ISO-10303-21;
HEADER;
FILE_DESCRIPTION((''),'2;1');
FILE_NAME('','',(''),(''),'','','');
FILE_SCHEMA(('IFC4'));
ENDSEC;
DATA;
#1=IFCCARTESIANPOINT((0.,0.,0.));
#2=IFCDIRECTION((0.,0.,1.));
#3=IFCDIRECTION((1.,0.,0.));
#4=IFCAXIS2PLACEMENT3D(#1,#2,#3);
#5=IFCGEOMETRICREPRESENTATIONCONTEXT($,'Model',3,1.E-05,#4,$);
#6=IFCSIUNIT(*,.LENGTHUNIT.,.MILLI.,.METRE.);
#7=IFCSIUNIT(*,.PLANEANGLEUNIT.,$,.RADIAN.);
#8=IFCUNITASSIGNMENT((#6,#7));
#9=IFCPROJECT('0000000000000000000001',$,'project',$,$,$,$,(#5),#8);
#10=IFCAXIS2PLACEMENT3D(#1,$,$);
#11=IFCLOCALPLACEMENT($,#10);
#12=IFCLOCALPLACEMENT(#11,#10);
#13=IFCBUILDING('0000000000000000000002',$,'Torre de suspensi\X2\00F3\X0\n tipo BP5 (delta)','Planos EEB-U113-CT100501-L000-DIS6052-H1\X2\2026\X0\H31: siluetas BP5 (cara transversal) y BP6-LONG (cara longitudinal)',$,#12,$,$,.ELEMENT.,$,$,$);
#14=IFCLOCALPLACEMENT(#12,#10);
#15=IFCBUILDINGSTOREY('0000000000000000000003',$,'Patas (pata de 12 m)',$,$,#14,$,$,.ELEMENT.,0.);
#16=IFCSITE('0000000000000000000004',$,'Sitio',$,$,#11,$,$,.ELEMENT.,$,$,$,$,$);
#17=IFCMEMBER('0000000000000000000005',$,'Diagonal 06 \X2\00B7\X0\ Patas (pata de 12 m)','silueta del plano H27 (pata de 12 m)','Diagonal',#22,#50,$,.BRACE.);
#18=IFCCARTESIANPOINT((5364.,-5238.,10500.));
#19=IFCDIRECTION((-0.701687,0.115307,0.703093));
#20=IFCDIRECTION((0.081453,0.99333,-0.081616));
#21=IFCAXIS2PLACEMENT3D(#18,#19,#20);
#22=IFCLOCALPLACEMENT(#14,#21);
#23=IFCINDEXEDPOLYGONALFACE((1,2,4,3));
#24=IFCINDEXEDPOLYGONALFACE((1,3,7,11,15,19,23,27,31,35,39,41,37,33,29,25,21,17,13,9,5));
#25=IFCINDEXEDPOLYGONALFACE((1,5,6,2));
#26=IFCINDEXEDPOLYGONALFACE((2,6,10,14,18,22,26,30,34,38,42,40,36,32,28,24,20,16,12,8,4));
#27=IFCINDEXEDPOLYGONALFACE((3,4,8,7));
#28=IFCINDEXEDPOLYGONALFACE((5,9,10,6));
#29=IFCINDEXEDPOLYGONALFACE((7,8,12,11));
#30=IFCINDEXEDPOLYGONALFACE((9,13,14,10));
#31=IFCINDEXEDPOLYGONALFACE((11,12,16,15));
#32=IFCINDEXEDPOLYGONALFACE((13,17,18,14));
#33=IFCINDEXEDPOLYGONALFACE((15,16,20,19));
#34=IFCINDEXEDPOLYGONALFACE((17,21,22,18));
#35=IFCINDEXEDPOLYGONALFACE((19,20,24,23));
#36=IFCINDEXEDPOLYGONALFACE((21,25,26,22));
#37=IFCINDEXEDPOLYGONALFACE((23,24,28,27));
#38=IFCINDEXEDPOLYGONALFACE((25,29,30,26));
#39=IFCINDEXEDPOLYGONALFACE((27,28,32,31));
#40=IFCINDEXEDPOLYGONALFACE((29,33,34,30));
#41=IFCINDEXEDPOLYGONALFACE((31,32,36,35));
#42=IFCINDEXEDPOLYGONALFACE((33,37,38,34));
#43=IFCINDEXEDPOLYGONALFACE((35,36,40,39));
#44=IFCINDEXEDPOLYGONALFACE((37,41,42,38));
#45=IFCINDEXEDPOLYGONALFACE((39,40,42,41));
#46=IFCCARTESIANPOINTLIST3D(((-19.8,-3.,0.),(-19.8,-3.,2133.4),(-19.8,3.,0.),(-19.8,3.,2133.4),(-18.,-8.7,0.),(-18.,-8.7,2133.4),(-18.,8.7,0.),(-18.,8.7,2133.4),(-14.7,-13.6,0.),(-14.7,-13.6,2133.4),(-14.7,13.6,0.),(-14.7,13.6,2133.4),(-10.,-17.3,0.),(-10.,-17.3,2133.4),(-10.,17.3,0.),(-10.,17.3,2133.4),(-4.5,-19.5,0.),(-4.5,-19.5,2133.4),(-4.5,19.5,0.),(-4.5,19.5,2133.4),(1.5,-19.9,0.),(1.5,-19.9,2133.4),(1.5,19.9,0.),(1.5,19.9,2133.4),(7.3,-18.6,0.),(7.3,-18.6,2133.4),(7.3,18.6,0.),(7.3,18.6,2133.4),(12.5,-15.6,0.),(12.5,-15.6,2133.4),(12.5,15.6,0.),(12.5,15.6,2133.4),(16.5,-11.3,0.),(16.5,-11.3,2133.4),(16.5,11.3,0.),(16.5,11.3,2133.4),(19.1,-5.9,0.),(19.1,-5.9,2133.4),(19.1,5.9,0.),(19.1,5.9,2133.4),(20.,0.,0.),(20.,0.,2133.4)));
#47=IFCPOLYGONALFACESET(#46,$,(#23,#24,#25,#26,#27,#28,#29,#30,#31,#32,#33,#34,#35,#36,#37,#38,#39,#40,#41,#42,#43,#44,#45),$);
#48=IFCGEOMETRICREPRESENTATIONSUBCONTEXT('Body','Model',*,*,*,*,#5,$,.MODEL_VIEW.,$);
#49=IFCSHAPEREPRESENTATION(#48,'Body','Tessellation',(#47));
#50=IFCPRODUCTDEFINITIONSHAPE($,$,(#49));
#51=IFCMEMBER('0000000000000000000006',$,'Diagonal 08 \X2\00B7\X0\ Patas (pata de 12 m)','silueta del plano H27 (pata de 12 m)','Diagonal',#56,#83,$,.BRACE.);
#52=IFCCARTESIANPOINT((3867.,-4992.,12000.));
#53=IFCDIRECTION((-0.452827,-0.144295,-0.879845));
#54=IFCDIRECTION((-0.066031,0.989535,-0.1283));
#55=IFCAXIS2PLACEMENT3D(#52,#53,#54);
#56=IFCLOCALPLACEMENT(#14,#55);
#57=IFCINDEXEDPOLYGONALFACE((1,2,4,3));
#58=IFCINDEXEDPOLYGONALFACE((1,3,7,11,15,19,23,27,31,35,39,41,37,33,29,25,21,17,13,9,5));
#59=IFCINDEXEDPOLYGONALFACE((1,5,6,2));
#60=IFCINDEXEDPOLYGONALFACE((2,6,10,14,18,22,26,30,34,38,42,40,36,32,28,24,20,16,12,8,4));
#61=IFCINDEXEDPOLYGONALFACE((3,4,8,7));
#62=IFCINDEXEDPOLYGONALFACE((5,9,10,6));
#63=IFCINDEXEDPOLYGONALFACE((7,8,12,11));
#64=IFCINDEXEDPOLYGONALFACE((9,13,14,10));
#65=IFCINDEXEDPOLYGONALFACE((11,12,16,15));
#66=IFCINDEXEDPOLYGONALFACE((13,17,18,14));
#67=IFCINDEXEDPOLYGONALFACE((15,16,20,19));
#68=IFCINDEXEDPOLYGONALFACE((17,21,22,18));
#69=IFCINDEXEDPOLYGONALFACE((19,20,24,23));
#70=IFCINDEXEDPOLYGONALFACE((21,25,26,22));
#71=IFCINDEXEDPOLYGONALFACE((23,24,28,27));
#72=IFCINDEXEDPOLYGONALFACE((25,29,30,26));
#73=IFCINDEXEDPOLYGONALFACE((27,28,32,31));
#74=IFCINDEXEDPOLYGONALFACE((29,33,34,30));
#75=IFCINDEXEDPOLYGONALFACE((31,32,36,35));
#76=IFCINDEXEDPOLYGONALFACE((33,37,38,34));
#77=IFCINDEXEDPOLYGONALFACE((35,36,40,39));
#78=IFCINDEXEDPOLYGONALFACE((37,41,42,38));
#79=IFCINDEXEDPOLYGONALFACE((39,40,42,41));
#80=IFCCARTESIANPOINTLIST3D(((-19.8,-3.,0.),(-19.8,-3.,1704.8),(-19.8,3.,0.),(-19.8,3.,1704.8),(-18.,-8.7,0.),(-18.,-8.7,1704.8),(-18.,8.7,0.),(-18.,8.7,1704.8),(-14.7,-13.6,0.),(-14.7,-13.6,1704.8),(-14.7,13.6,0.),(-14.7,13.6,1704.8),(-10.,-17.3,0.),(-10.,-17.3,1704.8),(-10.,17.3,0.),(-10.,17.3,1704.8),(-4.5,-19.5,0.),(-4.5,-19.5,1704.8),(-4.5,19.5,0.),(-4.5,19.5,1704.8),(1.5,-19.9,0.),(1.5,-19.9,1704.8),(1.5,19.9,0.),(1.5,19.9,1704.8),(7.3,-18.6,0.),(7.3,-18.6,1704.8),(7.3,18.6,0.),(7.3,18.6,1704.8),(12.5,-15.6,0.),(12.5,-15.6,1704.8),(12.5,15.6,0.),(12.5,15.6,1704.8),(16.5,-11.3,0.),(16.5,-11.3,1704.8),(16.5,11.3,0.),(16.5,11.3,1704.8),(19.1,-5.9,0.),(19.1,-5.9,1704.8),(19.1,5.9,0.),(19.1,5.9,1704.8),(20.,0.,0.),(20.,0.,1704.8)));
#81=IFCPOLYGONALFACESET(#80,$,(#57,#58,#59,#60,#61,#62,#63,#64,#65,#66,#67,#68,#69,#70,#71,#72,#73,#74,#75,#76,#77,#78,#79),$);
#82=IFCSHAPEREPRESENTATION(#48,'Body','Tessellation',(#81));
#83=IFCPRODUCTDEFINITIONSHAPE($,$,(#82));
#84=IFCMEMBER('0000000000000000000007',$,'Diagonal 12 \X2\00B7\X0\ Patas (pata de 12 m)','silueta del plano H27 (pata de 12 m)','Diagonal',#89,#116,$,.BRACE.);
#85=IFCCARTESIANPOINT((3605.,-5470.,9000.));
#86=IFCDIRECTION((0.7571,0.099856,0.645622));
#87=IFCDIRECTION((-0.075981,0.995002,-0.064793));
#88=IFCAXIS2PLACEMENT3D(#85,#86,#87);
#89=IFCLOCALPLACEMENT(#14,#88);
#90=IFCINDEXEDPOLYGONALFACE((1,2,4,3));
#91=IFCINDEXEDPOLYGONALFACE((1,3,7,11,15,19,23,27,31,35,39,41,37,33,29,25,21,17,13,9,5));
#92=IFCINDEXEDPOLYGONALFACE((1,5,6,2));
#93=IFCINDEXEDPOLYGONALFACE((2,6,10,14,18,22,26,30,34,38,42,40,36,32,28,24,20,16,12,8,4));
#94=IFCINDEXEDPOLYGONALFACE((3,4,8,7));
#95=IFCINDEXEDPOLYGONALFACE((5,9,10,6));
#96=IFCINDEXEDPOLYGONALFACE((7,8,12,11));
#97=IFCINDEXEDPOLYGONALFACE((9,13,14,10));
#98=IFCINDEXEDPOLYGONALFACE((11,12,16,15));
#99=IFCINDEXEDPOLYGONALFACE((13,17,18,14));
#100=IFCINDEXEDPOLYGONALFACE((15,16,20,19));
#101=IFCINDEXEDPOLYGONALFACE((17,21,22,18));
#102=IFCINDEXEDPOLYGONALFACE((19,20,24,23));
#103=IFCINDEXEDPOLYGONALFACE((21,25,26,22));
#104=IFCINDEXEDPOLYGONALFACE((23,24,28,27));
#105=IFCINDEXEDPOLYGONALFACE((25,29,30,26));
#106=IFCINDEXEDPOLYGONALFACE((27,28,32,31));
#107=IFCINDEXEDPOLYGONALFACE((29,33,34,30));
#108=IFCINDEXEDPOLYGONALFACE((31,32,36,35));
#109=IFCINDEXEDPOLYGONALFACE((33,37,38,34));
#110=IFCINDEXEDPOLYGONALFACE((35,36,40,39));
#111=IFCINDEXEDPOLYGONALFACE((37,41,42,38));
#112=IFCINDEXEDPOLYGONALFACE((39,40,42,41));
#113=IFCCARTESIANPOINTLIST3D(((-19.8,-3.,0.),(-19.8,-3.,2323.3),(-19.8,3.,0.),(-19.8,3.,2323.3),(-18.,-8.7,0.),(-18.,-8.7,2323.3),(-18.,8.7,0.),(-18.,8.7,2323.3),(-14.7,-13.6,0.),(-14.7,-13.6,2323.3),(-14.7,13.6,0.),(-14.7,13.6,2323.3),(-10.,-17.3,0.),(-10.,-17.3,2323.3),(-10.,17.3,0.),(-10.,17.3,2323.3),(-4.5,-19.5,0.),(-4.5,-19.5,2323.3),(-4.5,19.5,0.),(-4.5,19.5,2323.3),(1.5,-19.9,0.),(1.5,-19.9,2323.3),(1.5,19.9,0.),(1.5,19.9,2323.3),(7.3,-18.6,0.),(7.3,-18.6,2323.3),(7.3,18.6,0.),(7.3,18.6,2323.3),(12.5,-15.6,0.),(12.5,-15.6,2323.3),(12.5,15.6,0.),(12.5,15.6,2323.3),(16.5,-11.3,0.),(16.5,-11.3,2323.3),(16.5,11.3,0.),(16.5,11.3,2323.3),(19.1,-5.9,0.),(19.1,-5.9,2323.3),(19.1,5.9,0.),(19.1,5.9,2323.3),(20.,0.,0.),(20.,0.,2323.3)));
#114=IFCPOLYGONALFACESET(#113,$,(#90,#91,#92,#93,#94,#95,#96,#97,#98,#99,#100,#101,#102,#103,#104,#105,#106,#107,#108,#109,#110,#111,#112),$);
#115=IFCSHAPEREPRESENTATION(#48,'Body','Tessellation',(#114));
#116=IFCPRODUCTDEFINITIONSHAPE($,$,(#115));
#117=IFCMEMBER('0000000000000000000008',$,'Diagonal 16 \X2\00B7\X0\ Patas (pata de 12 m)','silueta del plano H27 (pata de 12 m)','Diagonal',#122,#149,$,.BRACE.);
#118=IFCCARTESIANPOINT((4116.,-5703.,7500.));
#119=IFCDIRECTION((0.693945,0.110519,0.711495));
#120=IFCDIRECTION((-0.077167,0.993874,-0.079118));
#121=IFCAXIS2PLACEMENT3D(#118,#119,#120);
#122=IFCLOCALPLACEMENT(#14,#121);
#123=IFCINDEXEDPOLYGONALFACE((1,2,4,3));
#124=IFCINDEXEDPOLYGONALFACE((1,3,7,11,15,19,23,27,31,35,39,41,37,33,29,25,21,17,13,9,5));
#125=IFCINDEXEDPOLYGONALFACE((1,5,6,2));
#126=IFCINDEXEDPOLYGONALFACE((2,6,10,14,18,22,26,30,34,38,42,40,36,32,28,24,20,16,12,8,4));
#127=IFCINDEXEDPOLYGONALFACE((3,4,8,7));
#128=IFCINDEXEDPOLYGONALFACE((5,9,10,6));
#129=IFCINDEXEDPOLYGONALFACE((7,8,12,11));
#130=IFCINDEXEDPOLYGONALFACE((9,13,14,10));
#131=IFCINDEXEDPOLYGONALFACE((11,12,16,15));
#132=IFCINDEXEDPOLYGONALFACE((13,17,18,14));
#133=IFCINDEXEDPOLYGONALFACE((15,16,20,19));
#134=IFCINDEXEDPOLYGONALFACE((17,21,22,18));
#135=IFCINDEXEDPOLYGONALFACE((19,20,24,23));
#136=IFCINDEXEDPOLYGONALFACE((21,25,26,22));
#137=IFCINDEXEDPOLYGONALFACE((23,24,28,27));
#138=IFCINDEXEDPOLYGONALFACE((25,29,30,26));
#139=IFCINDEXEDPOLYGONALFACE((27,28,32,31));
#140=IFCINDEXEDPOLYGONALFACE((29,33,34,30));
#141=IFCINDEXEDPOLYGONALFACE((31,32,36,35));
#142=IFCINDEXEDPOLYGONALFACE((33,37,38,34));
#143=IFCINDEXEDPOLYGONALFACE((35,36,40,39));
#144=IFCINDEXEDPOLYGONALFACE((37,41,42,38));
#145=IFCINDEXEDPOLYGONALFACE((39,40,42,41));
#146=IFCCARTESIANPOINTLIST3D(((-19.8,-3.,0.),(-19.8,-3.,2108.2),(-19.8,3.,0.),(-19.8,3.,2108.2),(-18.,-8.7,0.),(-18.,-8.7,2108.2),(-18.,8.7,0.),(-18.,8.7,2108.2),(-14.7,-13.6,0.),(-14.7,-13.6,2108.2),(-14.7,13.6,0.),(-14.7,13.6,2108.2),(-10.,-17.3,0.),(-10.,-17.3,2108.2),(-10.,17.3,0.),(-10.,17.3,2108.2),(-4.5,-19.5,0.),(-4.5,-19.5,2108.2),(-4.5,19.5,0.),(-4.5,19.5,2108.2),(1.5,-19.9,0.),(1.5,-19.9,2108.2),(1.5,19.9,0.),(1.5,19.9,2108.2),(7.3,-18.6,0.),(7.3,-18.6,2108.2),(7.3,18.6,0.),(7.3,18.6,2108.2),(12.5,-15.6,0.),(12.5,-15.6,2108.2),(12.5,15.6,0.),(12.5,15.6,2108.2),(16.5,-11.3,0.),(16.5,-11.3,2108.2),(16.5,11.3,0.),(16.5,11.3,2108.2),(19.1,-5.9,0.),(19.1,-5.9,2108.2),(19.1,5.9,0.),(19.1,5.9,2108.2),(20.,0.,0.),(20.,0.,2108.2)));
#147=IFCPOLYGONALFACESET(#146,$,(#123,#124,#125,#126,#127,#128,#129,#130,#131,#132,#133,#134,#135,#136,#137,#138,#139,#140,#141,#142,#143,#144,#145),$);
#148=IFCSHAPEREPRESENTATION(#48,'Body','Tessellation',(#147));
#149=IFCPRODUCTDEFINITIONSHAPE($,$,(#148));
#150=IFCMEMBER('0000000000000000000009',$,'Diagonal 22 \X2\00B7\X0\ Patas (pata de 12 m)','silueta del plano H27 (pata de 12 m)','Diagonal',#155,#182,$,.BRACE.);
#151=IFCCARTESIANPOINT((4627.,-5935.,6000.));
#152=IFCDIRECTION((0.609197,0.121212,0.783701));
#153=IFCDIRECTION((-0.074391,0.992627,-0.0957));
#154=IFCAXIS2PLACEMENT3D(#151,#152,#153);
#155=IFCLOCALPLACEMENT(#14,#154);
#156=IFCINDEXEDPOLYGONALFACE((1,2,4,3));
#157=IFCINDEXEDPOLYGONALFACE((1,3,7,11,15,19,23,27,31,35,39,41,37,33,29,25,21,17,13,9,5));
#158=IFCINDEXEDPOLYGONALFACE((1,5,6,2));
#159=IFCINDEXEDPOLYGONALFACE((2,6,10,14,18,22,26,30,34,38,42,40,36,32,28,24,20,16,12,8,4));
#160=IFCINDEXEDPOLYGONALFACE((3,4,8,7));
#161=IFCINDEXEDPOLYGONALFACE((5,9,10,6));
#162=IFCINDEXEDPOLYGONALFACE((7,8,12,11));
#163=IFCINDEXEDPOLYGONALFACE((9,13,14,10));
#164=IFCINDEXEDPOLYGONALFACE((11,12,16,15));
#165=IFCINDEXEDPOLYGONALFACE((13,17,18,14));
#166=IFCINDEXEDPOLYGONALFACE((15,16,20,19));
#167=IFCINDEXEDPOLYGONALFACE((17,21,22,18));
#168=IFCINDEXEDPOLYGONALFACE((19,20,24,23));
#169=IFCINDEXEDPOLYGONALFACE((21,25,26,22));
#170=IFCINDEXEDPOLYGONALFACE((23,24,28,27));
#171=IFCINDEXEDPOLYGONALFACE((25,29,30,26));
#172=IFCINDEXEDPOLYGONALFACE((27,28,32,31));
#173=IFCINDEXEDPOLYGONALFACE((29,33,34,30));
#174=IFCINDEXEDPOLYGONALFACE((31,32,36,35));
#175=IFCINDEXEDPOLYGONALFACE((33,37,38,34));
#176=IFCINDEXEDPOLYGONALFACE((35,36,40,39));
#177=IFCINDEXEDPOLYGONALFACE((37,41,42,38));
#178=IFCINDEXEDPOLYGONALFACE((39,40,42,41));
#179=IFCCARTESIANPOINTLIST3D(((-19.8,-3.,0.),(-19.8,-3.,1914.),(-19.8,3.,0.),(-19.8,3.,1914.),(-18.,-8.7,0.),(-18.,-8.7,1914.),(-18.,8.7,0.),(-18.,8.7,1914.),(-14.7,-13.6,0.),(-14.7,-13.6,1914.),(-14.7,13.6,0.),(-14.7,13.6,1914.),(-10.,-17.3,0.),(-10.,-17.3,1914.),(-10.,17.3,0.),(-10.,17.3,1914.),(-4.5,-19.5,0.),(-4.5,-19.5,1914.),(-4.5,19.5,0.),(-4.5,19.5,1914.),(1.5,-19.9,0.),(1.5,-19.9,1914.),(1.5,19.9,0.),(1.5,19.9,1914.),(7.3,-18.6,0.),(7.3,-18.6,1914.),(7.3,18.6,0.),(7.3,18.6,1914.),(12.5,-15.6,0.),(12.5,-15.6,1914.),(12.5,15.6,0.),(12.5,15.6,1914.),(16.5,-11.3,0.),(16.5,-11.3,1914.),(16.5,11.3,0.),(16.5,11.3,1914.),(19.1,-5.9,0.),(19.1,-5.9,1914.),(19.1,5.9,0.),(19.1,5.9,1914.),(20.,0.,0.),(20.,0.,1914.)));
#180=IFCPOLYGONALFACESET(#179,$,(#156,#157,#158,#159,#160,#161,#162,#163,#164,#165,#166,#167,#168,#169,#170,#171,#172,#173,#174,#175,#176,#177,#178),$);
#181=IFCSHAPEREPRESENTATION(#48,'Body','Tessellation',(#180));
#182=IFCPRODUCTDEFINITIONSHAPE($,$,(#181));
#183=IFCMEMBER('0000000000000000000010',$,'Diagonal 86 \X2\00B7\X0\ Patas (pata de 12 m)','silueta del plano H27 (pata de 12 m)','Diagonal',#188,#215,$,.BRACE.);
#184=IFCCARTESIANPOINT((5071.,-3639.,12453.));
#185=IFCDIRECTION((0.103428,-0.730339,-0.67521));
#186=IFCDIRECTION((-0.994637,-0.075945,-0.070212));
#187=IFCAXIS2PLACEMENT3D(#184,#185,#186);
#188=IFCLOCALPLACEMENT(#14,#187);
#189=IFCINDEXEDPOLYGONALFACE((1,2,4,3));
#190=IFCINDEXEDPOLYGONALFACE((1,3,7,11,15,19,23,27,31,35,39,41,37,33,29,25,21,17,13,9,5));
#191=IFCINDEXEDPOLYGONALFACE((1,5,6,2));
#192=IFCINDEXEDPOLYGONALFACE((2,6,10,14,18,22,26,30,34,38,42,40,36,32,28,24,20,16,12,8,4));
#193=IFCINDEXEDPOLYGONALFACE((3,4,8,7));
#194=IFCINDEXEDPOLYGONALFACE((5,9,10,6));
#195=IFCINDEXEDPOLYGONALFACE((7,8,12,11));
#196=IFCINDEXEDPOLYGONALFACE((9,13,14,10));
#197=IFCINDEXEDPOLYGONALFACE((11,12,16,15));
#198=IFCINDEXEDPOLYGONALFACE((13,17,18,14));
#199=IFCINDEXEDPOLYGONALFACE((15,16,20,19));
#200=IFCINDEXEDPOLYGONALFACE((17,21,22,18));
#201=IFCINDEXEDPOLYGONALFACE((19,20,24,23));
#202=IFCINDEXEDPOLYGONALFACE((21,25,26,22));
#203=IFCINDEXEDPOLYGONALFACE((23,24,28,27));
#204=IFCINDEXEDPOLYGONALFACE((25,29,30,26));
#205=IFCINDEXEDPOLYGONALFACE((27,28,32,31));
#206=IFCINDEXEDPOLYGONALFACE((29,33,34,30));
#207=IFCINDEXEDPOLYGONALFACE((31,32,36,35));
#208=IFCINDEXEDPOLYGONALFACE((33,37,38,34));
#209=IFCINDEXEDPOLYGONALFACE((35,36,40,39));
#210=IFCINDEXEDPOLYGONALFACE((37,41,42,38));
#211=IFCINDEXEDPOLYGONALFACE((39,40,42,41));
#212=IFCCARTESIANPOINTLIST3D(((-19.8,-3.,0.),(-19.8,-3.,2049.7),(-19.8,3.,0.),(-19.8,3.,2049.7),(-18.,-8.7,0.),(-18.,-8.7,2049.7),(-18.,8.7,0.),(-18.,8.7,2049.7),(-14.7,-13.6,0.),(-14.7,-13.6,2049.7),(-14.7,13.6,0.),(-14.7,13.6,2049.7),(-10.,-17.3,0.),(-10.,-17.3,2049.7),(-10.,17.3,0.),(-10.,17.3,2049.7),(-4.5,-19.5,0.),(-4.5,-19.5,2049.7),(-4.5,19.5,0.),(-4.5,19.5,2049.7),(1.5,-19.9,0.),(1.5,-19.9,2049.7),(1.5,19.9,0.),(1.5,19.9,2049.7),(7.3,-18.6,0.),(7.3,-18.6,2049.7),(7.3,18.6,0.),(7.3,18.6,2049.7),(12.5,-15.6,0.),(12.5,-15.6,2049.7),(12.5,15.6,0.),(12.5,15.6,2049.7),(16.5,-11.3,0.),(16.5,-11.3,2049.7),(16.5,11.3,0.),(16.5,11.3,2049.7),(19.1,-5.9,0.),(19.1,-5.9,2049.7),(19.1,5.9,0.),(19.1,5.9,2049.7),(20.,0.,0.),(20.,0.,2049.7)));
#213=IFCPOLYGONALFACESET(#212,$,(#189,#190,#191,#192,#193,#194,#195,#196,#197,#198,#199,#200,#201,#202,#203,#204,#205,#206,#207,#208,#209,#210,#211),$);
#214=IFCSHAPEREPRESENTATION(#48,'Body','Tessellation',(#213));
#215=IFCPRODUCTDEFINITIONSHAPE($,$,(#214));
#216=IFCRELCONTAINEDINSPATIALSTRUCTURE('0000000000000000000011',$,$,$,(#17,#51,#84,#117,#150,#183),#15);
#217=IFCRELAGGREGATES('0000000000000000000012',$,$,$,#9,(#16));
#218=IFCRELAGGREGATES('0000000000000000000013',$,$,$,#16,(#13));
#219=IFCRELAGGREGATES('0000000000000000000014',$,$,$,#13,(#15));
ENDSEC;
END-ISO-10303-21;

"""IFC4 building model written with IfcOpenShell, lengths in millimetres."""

from ifc_helpers import new_model, si_unit, frame, origin, origin_with_axes, place, context, subcontext, project, spatial, circle, extrude, element, save


model = new_model("IFC4")

# Units and contexts
model_context = context("Model", 3, precision=1e-05, world=origin_with_axes())
body_context = subcontext(model_context, "Body", "Model", "MODEL_VIEW")
ifc_project = project(units=[si_unit("LENGTHUNIT", "METRE", prefix="MILLI"), si_unit("PLANEANGLEUNIT", "RADIAN")], contexts=[model_context])

# Site, building, storey
site_placement = place(None, origin())
site = spatial("IfcSite", under=ifc_project, at=site_placement, Name="Sitio", CompositionType="ELEMENT")
building_placement = place(site_placement, origin())
building = spatial("IfcBuilding", under=site, at=building_placement, Name="Torre de suspensión tipo BP5 (delta)", Description="Planos EEB-U113-CT100501-L000-DIS6052-H1…H31: siluetas BP5 (cara transversal) y BP6-LONG (cara longitudinal)", CompositionType="ELEMENT")
storey_placement = place(building_placement, origin())
storey = spatial("IfcBuildingStorey", under=building, at=storey_placement, Name="Patas (pata de 12 m)", CompositionType="ELEMENT", Elevation=0.0)

# Members
member_1_placement = place(storey_placement, frame((5364.0, -5238.0, 10500.0), z_axis=(-0.701687, 0.115307, 0.703093), x_axis=(0.081453, 0.99333, -0.081616)))
element("IfcMember", 1, at=member_1_placement, inside=storey, Name="Diagonal 06 · Patas (pata de 12 m)", Description="silueta del plano H27 (pata de 12 m)", ObjectType="Diagonal", PredefinedType="BRACE", context=body_context, shape_type="SweptSolid", body=[
    extrude(circle(Radius=20.0), None, (0.0, 0.0, 1.0), 2133.4),
])
member_2_placement = place(storey_placement, frame((3867.0, -4992.0, 12000.0), z_axis=(-0.452827, -0.144295, -0.879845), x_axis=(-0.066031, 0.989535, -0.1283)))
element("IfcMember", 2, at=member_2_placement, inside=storey, Name="Diagonal 08 · Patas (pata de 12 m)", Description="silueta del plano H27 (pata de 12 m)", ObjectType="Diagonal", PredefinedType="BRACE", context=body_context, shape_type="SweptSolid", body=[
    extrude(circle(Radius=20.0), None, (0.0, 0.0, 1.0), 1704.8),
])
member_3_placement = place(storey_placement, frame((3605.0, -5470.0, 9000.0), z_axis=(0.7571, 0.099856, 0.645622), x_axis=(-0.075981, 0.995002, -0.064793)))
element("IfcMember", 3, at=member_3_placement, inside=storey, Name="Diagonal 12 · Patas (pata de 12 m)", Description="silueta del plano H27 (pata de 12 m)", ObjectType="Diagonal", PredefinedType="BRACE", context=body_context, shape_type="SweptSolid", body=[
    extrude(circle(Radius=20.0), None, (0.0, 0.0, 1.0), 2323.3),
])
member_4_placement = place(storey_placement, frame((4116.0, -5703.0, 7500.0), z_axis=(0.693945, 0.110519, 0.711495), x_axis=(-0.077167, 0.993874, -0.079118)))
element("IfcMember", 4, at=member_4_placement, inside=storey, Name="Diagonal 16 · Patas (pata de 12 m)", Description="silueta del plano H27 (pata de 12 m)", ObjectType="Diagonal", PredefinedType="BRACE", context=body_context, shape_type="SweptSolid", body=[
    extrude(circle(Radius=20.0), None, (0.0, 0.0, 1.0), 2108.2),
])
member_5_placement = place(storey_placement, frame((4627.0, -5935.0, 6000.0), z_axis=(0.609197, 0.121212, 0.783701), x_axis=(-0.074391, 0.992627, -0.0957)))
element("IfcMember", 5, at=member_5_placement, inside=storey, Name="Diagonal 22 · Patas (pata de 12 m)", Description="silueta del plano H27 (pata de 12 m)", ObjectType="Diagonal", PredefinedType="BRACE", context=body_context, shape_type="SweptSolid", body=[
    extrude(circle(Radius=20.0), None, (0.0, 0.0, 1.0), 1914.0),
])
member_6_placement = place(storey_placement, frame((5071.0, -3639.0, 12453.0), z_axis=(0.103428, -0.730339, -0.67521), x_axis=(-0.994637, -0.075945, -0.070212)))
element("IfcMember", 6, at=member_6_placement, inside=storey, Name="Diagonal 86 · Patas (pata de 12 m)", Description="silueta del plano H27 (pata de 12 m)", ObjectType="Diagonal", PredefinedType="BRACE", context=body_context, shape_type="SweptSolid", body=[
    extrude(circle(Radius=20.0), None, (0.0, 0.0, 1.0), 2049.7),
])

save(model, "model.ifc")
